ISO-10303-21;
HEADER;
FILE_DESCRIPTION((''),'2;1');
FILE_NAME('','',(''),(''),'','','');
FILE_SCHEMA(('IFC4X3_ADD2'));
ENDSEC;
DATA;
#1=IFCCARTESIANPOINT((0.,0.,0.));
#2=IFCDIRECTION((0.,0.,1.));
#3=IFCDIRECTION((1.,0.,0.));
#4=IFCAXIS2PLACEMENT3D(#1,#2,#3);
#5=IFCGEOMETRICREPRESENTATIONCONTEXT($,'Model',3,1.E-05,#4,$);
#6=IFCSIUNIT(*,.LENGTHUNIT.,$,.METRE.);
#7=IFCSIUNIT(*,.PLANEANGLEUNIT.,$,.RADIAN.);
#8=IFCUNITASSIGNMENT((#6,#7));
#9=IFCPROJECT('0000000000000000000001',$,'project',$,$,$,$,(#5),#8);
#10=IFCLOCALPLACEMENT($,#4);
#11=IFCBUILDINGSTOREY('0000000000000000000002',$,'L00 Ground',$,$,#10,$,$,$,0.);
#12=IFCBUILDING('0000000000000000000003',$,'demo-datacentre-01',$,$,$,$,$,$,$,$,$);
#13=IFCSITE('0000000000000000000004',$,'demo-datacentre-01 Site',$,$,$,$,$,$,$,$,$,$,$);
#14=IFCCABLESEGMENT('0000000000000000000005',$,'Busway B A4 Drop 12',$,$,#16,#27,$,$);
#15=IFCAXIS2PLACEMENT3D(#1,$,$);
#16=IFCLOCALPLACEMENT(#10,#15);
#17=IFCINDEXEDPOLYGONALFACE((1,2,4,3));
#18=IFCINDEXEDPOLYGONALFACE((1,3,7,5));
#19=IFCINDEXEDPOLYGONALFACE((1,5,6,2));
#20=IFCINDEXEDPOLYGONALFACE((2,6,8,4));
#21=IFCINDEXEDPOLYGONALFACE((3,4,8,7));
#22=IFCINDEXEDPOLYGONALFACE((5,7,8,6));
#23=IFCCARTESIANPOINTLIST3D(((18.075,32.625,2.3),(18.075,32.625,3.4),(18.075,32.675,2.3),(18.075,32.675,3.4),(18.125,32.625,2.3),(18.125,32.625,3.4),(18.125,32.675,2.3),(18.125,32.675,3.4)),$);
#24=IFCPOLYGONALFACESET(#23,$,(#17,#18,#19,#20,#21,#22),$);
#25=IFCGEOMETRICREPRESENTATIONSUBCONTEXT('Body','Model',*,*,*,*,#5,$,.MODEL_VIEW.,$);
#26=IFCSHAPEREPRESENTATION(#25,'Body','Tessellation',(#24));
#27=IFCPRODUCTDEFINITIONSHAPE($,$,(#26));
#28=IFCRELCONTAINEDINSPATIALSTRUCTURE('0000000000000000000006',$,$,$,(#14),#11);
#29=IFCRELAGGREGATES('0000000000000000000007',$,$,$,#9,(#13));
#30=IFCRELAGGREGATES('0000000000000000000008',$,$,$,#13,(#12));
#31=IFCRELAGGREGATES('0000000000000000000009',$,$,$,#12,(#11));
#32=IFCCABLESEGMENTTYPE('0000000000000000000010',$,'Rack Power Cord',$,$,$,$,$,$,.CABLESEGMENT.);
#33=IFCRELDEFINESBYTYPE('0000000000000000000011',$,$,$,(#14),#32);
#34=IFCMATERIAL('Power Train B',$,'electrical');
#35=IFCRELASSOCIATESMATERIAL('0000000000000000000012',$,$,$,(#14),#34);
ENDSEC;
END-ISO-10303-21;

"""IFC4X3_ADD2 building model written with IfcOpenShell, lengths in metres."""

from ifc_helpers import new_model, si_unit, frame, origin_with_axes, place, context, subcontext, project, spatial, rectangle, extrude, material, type_object, element, save


model = new_model("IFC4X3_ADD2")

# Units and contexts
model_context = context("Model", 3, precision=1e-05, world=origin_with_axes())
body_context = subcontext(model_context, "Body", "Model", "MODEL_VIEW")
ifc_project = project(units=[si_unit("LENGTHUNIT", "METRE"), si_unit("PLANEANGLEUNIT", "RADIAN")], contexts=[model_context])

# Site, building, storey
site = spatial("IfcSite", under=ifc_project, Name="demo-datacentre-01 Site")
building = spatial("IfcBuilding", under=site, Name="demo-datacentre-01")
storey_placement = place(None, origin_with_axes())
storey = spatial("IfcBuildingStorey", under=building, at=storey_placement, Name="L00 Ground", Elevation=0.0)

# Shared definitions
ifc_material_1 = material(Name="Power Train B", Category="electrical")

# Cable segment
cable_segment_type_1 = type_object("IfcCableSegmentType", Name="Rack Power Cord", PredefinedType="CABLESEGMENT")
for number, where, z_axis, x_axis, name in (
    (1, (18.1, 32.65, 3.4), (0.0, 0.0, -1.0), (1.0, 0.0, 0.0), "Busway B A4 Drop 12"),
):
    element("IfcCableSegment", number, at=place(storey_placement, frame(where, z_axis=z_axis, x_axis=x_axis)), inside=storey, type_object=cable_segment_type_1, material=ifc_material_1, Name=name, context=body_context, shape_type="SweptSolid", body=[
        extrude(rectangle(XDim=0.05, YDim=0.05), origin_with_axes(), (0.0, 0.0, 1.0), 1.1),
    ])

save(model, "model.ifc")
